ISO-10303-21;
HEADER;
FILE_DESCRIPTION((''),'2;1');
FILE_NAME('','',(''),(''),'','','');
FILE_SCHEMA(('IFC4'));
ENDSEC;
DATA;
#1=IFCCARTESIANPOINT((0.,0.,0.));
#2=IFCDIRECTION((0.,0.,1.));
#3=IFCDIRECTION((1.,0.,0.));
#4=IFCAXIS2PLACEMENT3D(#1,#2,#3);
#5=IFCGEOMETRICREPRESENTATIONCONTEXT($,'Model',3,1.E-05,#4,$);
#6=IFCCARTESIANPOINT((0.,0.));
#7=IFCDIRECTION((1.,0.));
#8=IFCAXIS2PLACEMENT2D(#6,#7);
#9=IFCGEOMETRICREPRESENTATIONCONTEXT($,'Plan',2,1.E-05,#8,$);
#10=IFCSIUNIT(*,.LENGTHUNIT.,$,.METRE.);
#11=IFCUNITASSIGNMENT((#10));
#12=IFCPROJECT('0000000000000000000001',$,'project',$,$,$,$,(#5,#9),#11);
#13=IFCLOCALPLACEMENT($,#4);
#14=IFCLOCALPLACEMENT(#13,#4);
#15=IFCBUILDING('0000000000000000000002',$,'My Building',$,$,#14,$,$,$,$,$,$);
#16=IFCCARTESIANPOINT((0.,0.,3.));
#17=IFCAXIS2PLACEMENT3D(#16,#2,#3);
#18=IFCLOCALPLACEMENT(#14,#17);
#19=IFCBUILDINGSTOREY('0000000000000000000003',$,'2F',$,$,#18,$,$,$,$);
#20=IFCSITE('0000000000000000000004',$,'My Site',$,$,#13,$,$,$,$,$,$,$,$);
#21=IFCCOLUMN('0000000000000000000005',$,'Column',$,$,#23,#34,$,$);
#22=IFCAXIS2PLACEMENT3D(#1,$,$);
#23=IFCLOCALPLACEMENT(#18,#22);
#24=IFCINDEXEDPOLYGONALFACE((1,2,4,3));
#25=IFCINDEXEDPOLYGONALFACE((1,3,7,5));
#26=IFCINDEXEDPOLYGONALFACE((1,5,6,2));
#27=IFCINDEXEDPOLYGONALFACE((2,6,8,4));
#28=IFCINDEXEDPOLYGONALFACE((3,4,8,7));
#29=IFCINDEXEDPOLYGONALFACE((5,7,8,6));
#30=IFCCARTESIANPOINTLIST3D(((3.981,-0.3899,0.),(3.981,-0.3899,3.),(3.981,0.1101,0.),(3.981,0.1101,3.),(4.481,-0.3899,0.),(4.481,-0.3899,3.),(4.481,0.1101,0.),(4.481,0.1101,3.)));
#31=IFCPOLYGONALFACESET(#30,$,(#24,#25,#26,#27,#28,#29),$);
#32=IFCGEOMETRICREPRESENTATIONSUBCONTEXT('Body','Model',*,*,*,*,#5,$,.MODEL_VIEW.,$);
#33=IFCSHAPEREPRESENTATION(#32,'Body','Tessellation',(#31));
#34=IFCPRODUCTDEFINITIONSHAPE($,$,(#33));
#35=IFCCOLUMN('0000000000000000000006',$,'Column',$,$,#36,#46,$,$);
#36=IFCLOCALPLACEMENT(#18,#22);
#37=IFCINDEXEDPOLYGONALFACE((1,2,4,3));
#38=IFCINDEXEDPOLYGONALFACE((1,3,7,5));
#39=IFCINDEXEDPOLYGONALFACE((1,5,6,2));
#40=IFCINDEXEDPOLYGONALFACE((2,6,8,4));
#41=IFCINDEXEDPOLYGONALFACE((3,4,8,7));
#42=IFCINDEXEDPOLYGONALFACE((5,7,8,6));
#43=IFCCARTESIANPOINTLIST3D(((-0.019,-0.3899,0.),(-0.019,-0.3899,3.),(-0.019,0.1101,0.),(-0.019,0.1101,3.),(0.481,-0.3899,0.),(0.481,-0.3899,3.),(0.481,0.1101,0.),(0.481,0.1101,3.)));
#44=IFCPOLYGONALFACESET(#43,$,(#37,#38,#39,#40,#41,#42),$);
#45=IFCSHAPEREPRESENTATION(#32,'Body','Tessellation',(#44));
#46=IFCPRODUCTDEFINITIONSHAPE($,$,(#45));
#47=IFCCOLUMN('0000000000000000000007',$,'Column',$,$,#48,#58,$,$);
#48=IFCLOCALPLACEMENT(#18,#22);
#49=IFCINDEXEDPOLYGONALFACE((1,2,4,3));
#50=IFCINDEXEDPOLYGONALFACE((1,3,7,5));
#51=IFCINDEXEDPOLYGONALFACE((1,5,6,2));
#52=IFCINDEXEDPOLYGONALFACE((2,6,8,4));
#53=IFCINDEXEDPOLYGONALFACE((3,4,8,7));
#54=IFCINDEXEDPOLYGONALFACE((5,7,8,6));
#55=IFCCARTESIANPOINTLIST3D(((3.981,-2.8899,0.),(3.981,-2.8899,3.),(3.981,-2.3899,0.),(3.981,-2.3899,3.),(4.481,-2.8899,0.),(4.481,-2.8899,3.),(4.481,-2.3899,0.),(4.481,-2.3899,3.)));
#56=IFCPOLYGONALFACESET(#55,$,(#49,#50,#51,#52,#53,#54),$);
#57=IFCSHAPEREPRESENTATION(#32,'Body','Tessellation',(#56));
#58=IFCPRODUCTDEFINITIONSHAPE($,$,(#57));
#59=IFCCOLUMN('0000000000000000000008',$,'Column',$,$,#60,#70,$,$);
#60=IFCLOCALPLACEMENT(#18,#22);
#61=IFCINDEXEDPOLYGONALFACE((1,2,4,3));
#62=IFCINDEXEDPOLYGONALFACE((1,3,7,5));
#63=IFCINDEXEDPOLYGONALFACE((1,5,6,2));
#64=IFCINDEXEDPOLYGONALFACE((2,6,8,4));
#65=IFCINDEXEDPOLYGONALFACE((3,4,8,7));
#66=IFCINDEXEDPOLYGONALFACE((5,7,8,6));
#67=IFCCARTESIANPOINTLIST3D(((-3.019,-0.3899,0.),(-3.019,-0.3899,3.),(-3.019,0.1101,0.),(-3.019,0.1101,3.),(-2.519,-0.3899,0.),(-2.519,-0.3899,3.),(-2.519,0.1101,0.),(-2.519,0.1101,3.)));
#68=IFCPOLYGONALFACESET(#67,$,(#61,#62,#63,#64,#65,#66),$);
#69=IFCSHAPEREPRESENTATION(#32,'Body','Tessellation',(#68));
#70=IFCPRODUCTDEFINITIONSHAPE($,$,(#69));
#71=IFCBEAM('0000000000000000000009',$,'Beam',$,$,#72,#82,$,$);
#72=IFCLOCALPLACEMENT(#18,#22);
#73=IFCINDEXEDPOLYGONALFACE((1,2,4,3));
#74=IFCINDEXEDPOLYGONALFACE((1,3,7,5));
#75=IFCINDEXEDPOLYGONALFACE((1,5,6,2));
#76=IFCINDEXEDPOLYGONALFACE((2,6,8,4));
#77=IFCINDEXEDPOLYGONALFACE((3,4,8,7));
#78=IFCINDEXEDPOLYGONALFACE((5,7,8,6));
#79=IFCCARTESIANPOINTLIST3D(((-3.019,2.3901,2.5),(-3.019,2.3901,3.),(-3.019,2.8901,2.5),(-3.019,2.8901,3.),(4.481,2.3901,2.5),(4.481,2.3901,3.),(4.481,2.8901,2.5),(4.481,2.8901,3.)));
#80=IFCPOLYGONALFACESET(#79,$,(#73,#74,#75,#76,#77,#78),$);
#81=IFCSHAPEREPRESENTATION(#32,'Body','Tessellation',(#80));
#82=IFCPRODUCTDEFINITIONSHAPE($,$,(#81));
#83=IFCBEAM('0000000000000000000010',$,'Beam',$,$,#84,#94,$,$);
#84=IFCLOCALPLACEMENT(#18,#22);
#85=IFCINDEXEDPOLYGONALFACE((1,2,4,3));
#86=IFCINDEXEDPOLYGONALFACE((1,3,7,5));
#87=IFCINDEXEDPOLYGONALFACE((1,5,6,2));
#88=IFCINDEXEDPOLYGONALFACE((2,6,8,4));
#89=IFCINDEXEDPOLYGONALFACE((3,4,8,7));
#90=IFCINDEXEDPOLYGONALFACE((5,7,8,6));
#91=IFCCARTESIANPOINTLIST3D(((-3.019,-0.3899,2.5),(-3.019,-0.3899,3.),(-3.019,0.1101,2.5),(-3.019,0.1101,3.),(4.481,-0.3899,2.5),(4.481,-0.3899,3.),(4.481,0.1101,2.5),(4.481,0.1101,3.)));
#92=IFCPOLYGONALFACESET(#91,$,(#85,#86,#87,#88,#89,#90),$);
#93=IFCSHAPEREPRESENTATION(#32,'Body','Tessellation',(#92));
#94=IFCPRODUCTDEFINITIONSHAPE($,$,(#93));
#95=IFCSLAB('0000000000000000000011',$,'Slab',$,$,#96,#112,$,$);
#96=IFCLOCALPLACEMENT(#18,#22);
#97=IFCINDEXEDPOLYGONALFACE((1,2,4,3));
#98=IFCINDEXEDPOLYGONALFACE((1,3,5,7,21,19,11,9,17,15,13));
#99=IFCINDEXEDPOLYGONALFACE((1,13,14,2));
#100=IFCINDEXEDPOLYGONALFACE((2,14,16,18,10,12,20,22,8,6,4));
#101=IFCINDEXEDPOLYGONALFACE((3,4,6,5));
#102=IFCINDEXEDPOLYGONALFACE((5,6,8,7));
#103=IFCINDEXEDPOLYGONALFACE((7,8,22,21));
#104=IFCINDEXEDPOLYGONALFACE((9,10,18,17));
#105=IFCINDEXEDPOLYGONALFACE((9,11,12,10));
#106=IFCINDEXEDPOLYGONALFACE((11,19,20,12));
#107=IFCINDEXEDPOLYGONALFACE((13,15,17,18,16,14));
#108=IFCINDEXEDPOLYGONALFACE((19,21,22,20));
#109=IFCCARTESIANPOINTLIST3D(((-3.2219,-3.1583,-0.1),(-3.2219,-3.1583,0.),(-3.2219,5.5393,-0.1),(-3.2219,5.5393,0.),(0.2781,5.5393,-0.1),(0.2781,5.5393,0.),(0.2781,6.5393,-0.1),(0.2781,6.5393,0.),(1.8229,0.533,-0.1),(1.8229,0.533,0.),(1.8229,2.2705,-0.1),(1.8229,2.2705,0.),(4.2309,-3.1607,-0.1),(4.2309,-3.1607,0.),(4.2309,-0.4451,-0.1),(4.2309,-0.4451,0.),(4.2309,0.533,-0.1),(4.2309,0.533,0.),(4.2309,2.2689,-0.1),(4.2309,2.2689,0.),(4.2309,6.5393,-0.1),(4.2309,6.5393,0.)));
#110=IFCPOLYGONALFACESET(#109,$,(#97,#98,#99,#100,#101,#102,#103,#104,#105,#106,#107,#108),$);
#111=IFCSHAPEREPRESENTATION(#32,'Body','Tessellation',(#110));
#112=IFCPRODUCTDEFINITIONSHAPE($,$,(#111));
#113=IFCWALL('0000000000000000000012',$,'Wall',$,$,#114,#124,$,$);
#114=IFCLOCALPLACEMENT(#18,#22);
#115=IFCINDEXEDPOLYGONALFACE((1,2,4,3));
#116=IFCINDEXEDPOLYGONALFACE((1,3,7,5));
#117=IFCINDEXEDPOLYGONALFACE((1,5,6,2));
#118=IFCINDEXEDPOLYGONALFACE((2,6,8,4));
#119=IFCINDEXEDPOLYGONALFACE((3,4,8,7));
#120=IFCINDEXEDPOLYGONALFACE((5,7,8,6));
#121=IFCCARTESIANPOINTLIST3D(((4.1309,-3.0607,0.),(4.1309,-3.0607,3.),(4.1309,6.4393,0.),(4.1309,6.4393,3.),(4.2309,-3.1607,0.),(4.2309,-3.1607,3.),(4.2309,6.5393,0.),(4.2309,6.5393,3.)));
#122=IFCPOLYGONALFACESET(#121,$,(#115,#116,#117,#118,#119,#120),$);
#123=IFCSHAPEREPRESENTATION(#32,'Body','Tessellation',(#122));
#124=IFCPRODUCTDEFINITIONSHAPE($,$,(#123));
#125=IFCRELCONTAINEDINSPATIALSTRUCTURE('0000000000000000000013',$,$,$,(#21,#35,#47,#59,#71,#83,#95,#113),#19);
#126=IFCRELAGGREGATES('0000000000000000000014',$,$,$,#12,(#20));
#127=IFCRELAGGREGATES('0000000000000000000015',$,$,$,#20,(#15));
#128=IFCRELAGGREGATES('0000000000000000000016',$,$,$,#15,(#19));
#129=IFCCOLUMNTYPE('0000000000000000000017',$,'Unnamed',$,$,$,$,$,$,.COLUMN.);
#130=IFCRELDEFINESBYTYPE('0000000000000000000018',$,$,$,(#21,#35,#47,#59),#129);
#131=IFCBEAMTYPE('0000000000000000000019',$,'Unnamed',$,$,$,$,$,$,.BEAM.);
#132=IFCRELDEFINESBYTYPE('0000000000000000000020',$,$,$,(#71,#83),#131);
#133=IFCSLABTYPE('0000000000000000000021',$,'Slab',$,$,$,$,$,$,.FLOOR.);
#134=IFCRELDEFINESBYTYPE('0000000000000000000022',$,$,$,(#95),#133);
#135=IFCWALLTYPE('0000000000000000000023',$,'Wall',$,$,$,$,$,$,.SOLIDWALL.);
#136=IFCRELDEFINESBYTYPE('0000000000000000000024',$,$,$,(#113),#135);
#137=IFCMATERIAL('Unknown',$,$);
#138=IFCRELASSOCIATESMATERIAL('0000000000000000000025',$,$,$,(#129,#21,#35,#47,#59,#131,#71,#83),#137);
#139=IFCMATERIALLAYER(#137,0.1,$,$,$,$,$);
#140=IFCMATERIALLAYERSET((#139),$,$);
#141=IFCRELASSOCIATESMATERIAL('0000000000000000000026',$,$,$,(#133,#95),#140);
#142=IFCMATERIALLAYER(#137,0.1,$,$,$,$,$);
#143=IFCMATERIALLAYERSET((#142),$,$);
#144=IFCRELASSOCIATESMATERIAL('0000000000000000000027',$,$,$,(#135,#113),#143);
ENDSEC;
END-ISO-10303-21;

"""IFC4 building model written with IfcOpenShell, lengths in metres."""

from ifc_helpers import new_model, si_unit, frame, origin_with_axes, origin_2d_with_axis, place, context, subcontext, project, spatial, line, indexed_curve, rectangle, outline, extrude, material, layer, layer_set, layer_usage, material_profile, profile_set, profile_usage, type_object, element, save


model = new_model("IFC4")

# Units and contexts
model_context = context("Model", 3, precision=1e-05, world=origin_with_axes())
plan_context = context("Plan", 2, precision=1e-05, world=origin_2d_with_axis())
body_context_1 = subcontext(model_context, "Body", "Model", "MODEL_VIEW")
ifc_project = project(units=[si_unit("LENGTHUNIT", "METRE")], contexts=[model_context, plan_context])

# Site, building, storey
site_placement = place(None, origin_with_axes())
site = spatial("IfcSite", under=ifc_project, at=site_placement, Name="My Site")
building_placement = place(site_placement, origin_with_axes())
building = spatial("IfcBuilding", under=site, at=building_placement, Name="My Building")
storey_placement = place(building_placement, frame((0.0, 0.0, 3.0), z_axis=(0.0, 0.0, 1.0), x_axis=(1.0, 0.0, 0.0)))
storey = spatial("IfcBuildingStorey", under=building, at=storey_placement, Name="2F")

# Columns
ifc_material = material(Name="Unknown")
ifc_material_profile_1 = material_profile(ifc_material, rectangle(XDim=0.5, YDim=0.5))
ifc_profile_set_1 = profile_set([ifc_material_profile_1])
ifc_profile_usage_1 = profile_usage(ifc_profile_set_1, cardinal=7)
column_type = type_object("IfcColumnType", Name="Unnamed", PredefinedType="COLUMN", material=ifc_profile_set_1)
column_1_placement = place(storey_placement, frame((4.481, 0.1101, 0.0), z_axis=(0.0, 0.0, 1.0), x_axis=(1.0, 0.0, 0.0)))
element("IfcColumn", 1, at=column_1_placement, inside=storey, type_object=column_type, material=ifc_profile_usage_1, Name="Column", context=body_context_1, shape_type="SweptSolid", body=[
    extrude(rectangle(XDim=0.5, YDim=0.5), frame((-0.25, -0.25, 0.0), z_axis=(0.0, 0.0, 1.0), x_axis=(1.0, 0.0, 0.0)), (0.0, 0.0, 1.0), 3.0),
])
ifc_profile_usage_2 = profile_usage(ifc_profile_set_1, cardinal=7)
column_2_placement = place(storey_placement, frame((0.481, 0.1101, 0.0), z_axis=(0.0, 0.0, 1.0), x_axis=(1.0, 0.0, 0.0)))
element("IfcColumn", 2, at=column_2_placement, inside=storey, type_object=column_type, material=ifc_profile_usage_2, Name="Column", context=body_context_1, shape_type="SweptSolid", body=[
    extrude(rectangle(XDim=0.5, YDim=0.5), frame((-0.25, -0.25, 0.0), z_axis=(0.0, 0.0, 1.0), x_axis=(1.0, 0.0, 0.0)), (0.0, 0.0, 1.0), 3.0),
])
ifc_profile_usage_3 = profile_usage(ifc_profile_set_1, cardinal=7)
column_3_placement = place(storey_placement, frame((4.481, -2.3899, 0.0), z_axis=(0.0, 0.0, 1.0), x_axis=(1.0, 0.0, 0.0)))
element("IfcColumn", 3, at=column_3_placement, inside=storey, type_object=column_type, material=ifc_profile_usage_3, Name="Column", context=body_context_1, shape_type="SweptSolid", body=[
    extrude(rectangle(XDim=0.5, YDim=0.5), frame((-0.25, -0.25, 0.0), z_axis=(0.0, 0.0, 1.0), x_axis=(1.0, 0.0, 0.0)), (0.0, 0.0, 1.0), 3.0),
])
ifc_profile_usage_4 = profile_usage(ifc_profile_set_1, cardinal=7)
column_4_placement = place(storey_placement, frame((-2.519, 0.1101, 0.0), z_axis=(0.0, 0.0, 1.0), x_axis=(1.0, 0.0, 0.0)))
element("IfcColumn", 4, at=column_4_placement, inside=storey, type_object=column_type, material=ifc_profile_usage_4, Name="Column", context=body_context_1, shape_type="SweptSolid", body=[
    extrude(rectangle(XDim=0.5, YDim=0.5), frame((-0.25, -0.25, 0.0), z_axis=(0.0, 0.0, 1.0), x_axis=(1.0, 0.0, 0.0)), (0.0, 0.0, 1.0), 3.0),
])

# Beams
ifc_material_profile_2 = material_profile(ifc_material, rectangle(XDim=0.5, YDim=0.5))
ifc_profile_set_2 = profile_set([ifc_material_profile_2])
ifc_profile_usage_5 = profile_usage(ifc_profile_set_2, cardinal=7)
beam_type = type_object("IfcBeamType", Name="Unnamed", PredefinedType="BEAM", material=ifc_profile_set_2)
beam_1_placement = place(storey_placement, frame((4.481, 2.3901, 3.0), z_axis=(-1.0, 0.0, 0.0), x_axis=(0.0, -1.0, 0.0)))
element("IfcBeam", 5, at=beam_1_placement, inside=storey, type_object=beam_type, material=ifc_profile_usage_5, Name="Beam", context=body_context_1, shape_type="SweptSolid", body=[
    extrude(rectangle(XDim=0.5, YDim=0.5), frame((-0.25, -0.25, 0.0), z_axis=(0.0, 0.0, 1.0), x_axis=(1.0, 0.0, 0.0)), (0.0, 0.0, 1.0), 7.5),
])
ifc_profile_usage_6 = profile_usage(ifc_profile_set_2, cardinal=7)
beam_2_placement = place(storey_placement, frame((4.481, -0.3899, 3.0), z_axis=(-1.0, 0.0, 0.0), x_axis=(0.0, -1.0, 0.0)))
element("IfcBeam", 6, at=beam_2_placement, inside=storey, type_object=beam_type, material=ifc_profile_usage_6, Name="Beam", context=body_context_1, shape_type="SweptSolid", body=[
    extrude(rectangle(XDim=0.5, YDim=0.5), frame((-0.25, -0.25, 0.0), z_axis=(0.0, 0.0, 1.0), x_axis=(1.0, 0.0, 0.0)), (0.0, 0.0, 1.0), 7.5),
])

# Slab
ifc_layer_1 = layer(ifc_material, 0.1)
ifc_layer_set_1 = layer_set([ifc_layer_1])
ifc_layer_usage_1 = layer_usage(ifc_layer_set_1, "AXIS3", "POSITIVE", -0.1)
slab_type = type_object("IfcSlabType", Name="Slab", PredefinedType="FLOOR", material=ifc_layer_set_1)
slab_placement = place(storey_placement, frame((-3.2219, -3.1583, 0.0), z_axis=(0.0, 0.0, 1.0), x_axis=(1.0, 0.0, 0.0)))
element("IfcSlab", 7, at=slab_placement, inside=storey, type_object=slab_type, material=ifc_layer_usage_1, Name="Slab", context=body_context_1, shape_type="SweptSolid", body=[
    extrude(outline(indexed_curve([(0.0, 0.0), (0.0, 8.6976), (3.5, 8.6976), (3.5, 9.6976), (7.4528, 9.6976), (7.4528, 5.4272), (5.0448, 5.4288), (5.0448, 3.6912), (7.4528, 3.6912), (7.4528, 2.7132), (7.4528, -0.0024), (0.0, 0.0)])), frame((0.0, 0.0, -0.1), z_axis=(0.0, 0.0, 1.0), x_axis=(1.0, 0.0, 0.0)), (0.0, 0.0, 1.0), 0.1),
])

# Wall
ifc_layer_2 = layer(ifc_material, 0.1)
ifc_layer_set_2 = layer_set([ifc_layer_2])
ifc_layer_usage_2 = layer_usage(ifc_layer_set_2, "AXIS2", "POSITIVE", 0.0)
wall_type = type_object("IfcWallType", Name="Wall", PredefinedType="SOLIDWALL", material=ifc_layer_set_2)
wall_1_placement = place(storey_placement, frame((4.2309, -3.1607, 0.0), z_axis=(0.0, 0.0, 1.0), x_axis=(0.0, 1.0, 0.0)))
element("IfcWall", 8, at=wall_1_placement, inside=storey, type_object=wall_type, material=ifc_layer_usage_2, Name="Wall", context=body_context_1, shape_type="SweptSolid", body=[
    extrude(outline(indexed_curve([(0.0, 0.0), (0.1, 0.1), (9.6, 0.1), (9.7, 0.0)], segments=[line(1, 2, 3, 4, 1)])), origin_with_axes(), (0.0, 0.0, 1.0), 3.0),
])

save(model, "model.ifc")
